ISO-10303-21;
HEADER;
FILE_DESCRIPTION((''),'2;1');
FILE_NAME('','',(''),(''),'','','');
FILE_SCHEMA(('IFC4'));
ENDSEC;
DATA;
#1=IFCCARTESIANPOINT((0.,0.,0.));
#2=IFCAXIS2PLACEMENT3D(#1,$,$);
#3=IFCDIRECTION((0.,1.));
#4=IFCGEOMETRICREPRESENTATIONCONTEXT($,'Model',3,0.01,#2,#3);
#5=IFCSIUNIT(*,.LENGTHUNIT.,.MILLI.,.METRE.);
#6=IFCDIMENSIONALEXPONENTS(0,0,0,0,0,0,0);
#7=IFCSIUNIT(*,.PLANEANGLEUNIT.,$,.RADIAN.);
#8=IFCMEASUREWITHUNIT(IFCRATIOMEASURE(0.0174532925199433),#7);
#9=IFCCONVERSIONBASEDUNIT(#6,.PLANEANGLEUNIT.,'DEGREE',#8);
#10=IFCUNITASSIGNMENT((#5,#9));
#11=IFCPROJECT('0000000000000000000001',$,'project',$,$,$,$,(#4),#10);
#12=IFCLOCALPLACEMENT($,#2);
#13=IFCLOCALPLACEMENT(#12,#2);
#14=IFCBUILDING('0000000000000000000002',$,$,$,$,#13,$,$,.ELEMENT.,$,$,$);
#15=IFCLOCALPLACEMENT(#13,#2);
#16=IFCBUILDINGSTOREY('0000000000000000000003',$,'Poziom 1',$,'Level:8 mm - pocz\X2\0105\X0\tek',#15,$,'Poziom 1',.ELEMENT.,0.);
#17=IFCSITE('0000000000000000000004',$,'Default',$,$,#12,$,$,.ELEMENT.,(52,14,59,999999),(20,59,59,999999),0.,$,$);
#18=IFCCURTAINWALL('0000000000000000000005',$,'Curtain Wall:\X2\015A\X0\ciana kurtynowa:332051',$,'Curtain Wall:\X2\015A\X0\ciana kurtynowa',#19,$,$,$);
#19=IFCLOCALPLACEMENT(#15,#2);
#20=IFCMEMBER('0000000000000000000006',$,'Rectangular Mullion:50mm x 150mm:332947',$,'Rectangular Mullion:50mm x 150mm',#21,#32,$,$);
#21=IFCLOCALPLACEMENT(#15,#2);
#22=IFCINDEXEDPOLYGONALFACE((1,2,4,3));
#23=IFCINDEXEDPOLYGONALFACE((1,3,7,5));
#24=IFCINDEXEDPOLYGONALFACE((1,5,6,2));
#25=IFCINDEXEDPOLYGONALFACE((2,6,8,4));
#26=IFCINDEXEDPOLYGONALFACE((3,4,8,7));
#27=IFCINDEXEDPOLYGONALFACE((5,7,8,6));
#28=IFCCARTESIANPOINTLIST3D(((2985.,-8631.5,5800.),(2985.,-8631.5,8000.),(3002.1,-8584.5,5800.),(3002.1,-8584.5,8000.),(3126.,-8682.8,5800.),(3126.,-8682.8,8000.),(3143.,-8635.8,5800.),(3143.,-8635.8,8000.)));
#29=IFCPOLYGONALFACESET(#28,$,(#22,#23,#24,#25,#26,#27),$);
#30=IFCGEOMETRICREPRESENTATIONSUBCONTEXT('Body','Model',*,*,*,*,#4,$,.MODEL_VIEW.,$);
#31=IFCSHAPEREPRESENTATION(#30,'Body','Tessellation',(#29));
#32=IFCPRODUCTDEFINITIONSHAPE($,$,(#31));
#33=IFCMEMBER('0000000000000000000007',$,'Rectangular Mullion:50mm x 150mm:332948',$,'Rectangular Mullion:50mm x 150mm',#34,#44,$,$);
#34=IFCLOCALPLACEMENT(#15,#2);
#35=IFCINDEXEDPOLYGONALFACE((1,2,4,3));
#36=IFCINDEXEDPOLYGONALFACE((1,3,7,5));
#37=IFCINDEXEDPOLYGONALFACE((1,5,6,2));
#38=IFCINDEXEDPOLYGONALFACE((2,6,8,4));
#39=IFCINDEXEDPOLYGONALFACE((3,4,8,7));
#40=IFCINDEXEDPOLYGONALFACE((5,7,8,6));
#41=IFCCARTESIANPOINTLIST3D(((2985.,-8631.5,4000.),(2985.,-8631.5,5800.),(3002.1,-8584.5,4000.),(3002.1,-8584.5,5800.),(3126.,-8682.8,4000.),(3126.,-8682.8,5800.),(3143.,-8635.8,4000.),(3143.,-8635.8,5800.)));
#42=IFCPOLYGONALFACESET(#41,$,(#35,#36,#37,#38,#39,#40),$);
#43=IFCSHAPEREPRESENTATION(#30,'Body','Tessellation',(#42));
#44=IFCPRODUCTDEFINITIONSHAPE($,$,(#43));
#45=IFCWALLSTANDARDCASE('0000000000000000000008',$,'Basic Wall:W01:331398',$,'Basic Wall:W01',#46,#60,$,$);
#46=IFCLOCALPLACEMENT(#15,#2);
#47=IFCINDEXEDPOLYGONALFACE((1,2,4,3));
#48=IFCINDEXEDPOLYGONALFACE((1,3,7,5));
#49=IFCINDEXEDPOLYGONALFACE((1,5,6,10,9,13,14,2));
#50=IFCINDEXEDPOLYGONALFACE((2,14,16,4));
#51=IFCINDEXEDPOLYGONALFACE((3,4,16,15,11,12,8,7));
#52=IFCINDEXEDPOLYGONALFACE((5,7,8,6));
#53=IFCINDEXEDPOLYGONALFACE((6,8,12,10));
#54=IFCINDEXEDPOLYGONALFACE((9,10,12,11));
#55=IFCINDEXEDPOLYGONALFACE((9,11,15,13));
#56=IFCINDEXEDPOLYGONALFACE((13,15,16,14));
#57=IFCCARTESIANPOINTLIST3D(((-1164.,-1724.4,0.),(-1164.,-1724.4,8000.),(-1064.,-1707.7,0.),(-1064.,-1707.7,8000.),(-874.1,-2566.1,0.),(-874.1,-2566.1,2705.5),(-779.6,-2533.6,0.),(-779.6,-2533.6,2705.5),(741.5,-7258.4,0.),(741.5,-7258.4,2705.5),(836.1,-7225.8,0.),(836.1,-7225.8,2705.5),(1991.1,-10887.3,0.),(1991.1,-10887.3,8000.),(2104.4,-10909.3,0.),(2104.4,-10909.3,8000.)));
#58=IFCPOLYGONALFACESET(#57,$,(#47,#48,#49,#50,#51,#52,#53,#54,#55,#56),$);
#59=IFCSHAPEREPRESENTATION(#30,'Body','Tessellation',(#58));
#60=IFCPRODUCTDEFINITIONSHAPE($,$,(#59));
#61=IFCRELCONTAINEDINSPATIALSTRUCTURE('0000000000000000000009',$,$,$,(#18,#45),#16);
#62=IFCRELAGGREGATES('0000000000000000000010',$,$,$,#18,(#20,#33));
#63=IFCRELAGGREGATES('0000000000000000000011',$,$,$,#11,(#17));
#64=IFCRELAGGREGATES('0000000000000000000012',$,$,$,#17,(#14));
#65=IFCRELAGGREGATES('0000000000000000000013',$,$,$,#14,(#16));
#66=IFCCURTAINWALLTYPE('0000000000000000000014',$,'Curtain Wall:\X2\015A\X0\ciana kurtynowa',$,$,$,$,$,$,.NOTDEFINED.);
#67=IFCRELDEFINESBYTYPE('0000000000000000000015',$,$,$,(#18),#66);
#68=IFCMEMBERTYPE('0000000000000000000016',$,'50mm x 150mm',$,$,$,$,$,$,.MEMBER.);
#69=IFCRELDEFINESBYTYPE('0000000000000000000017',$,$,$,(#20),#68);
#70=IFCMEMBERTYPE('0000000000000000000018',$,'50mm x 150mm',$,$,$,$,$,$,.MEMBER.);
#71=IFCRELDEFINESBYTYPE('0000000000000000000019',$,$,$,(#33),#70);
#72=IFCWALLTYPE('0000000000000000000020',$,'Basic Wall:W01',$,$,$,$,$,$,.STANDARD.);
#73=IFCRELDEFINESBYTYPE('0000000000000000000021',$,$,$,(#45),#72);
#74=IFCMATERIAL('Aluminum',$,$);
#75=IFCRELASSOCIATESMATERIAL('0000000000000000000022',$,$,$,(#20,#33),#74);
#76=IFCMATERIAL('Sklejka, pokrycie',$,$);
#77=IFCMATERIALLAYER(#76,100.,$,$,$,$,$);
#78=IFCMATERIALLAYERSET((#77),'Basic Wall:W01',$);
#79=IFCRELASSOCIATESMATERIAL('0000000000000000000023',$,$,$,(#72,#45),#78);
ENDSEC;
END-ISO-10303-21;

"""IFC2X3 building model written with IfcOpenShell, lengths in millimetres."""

from ifc_helpers import new_model, entity, si_unit, converted_unit, direction, frame, frame_2d, origin, origin_2d_with_axis, place, context, subcontext, project, spatial, polyline, rectangle, outline, extrude, source, transform, mapped, material, layer, layer_set, layer_usage, type_object, type_shapes, element, aggregate, save


model = new_model("IFC2X3")

# Units and contexts
model_context = context("Model", 3, precision=0.01, world=origin(), true_north=direction((0.0, 1.0)))
body_context = subcontext(model_context, "Body", "Model", "MODEL_VIEW")
ifc_project = project(units=[si_unit("LENGTHUNIT", "METRE", prefix="MILLI"), converted_unit("PLANEANGLEUNIT", "DEGREE", entity("IfcRatioMeasure", 0.0174532925199433), si_unit("PLANEANGLEUNIT", "RADIAN"), dimensions=[0, 0, 0, 0, 0, 0, 0])], contexts=[model_context])

# Site, building, storey
site_placement = place(None, origin())
site = spatial("IfcSite", under=ifc_project, at=site_placement, Name="Default", CompositionType="ELEMENT", RefLatitude=(52, 14, 59, 999999), RefLongitude=(20, 59, 59, 999999), RefElevation=0.0)
building_placement = place(site_placement, origin())
building = spatial("IfcBuilding", under=site, at=building_placement, CompositionType="ELEMENT")
storey_placement = place(building_placement, origin())
storey = spatial("IfcBuildingStorey", under=building, at=storey_placement, Name="Poziom 1", ObjectType="Level:8 mm - początek", LongName="Poziom 1", CompositionType="ELEMENT", Elevation=0.0)

# Curtain wall, members
curtain_wall_type = type_object("IfcCurtainWallType", Name="Curtain Wall:Ściana kurtynowa", PredefinedType="NOTDEFINED")
curtain_wall_placement = place(storey_placement, origin())
curtain_wall = element("IfcCurtainWall", 1, at=curtain_wall_placement, inside=storey, type_object=curtain_wall_type, Name="Curtain Wall:Ściana kurtynowa:332051", ObjectType="Curtain Wall:Ściana kurtynowa")
ifc_material_1 = material(Name="Aluminum")
member_type_1 = type_object("IfcMemberType", Name="50mm x 150mm", PredefinedType="MEMBER")
shared_shape_1 = source(origin(), body_context, "Body", "SweptSolid", [
    extrude(rectangle(XDim=150.0, YDim=50.0, at=origin_2d_with_axis()), frame((0.0, 0.0, -2200.0), z_axis=(0.0, 0.0, 1.0), x_axis=(0.0, -1.0, 0.0)), (0.0, 0.0, 1.0), 2200.0),
])
type_shapes(member_type_1, [shared_shape_1])
member_1_placement = place(storey_placement, frame((3064.0, -8633.7, 5800.0), z_axis=(0.0, 0.0, -1.0), x_axis=(0.341586, 0.939851, 0.0)))
member_1 = element("IfcMember", 2, at=member_1_placement, type_object=member_type_1, material=ifc_material_1, Name="Rectangular Mullion:50mm x 150mm:332947", ObjectType="Rectangular Mullion:50mm x 150mm", context=body_context, shape_type="MappedRepresentation", body=[
    mapped(shared_shape_1, transform((0.0, 0.0, 0.0), scale=1.0)),
])
member_type_2 = type_object("IfcMemberType", Name="50mm x 150mm", PredefinedType="MEMBER")
shared_shape_2 = source(origin(), body_context, "Body", "SweptSolid", [
    extrude(rectangle(XDim=150.0, YDim=50.0, at=origin_2d_with_axis()), frame((0.0, 0.0, -1800.0), z_axis=(0.0, 0.0, 1.0), x_axis=(0.0, -1.0, 0.0)), (0.0, 0.0, 1.0), 1800.0),
])
type_shapes(member_type_2, [shared_shape_2])
member_2_placement = place(storey_placement, frame((3064.0, -8633.7, 4000.0), z_axis=(0.0, 0.0, -1.0), x_axis=(0.341586, 0.939851, 0.0)))
member_2 = element("IfcMember", 3, at=member_2_placement, type_object=member_type_2, material=ifc_material_1, Name="Rectangular Mullion:50mm x 150mm:332948", ObjectType="Rectangular Mullion:50mm x 150mm", context=body_context, shape_type="MappedRepresentation", body=[
    mapped(shared_shape_2, transform((0.0, 0.0, 0.0), scale=1.0)),
])
aggregate(curtain_wall, [member_1, member_2])

# Wall, opening
ifc_material_2 = material(Name="Sklejka, pokrycie")
ifc_layer_1 = layer(ifc_material_2, 100.0)
ifc_layer_set_1 = layer_set([ifc_layer_1], Name="Basic Wall:W01")
ifc_layer_usage_1 = layer_usage(ifc_layer_set_1, "AXIS2", "NEGATIVE", 50.0)
wall_type_1 = type_object("IfcWallType", Name="Basic Wall:W01", PredefinedType="STANDARD", material=ifc_layer_set_1)
wall_1_placement = place(storey_placement, frame((2057.1, -10925.6, 0.0), z_axis=(0.0, 0.0, 1.0), x_axis=(-0.325568, 0.945519, 0.0)))
wall_1 = element("IfcWallStandardCase", 4, at=wall_1_placement, inside=storey, type_object=wall_type_1, material=ifc_layer_usage_1, Name="Basic Wall:W01:331398", ObjectType="Basic Wall:W01", context=body_context, shape_type="SweptSolid", body=[
    extrude(outline(polyline([(0.0, -50.0), (9731.8, -50.0), (9748.6, 50.0), (57.7, 50.0), (0.0, -50.0)])), origin(), (0.0, 0.0, 1.0), 8000.0),
])
opening_1_placement = place(wall_1_placement, origin())
element("IfcOpeningElement", 5, at=opening_1_placement, cuts=wall_1, ObjectType="Opening", context=body_context, shape_type="SweptSolid", body=[
    extrude(rectangle(XDim=2714.3, YDim=4962.6, at=frame_2d((0.0, 0.0), x_axis=(1.0, 0.0))), frame((6377.1, -50.0, 1348.3), z_axis=(0.0, 1.0, 0.0), x_axis=(0.0, 0.0, -1.0)), (0.0, 0.0, 1.0), 100.0),
])

save(model, "model.ifc")
